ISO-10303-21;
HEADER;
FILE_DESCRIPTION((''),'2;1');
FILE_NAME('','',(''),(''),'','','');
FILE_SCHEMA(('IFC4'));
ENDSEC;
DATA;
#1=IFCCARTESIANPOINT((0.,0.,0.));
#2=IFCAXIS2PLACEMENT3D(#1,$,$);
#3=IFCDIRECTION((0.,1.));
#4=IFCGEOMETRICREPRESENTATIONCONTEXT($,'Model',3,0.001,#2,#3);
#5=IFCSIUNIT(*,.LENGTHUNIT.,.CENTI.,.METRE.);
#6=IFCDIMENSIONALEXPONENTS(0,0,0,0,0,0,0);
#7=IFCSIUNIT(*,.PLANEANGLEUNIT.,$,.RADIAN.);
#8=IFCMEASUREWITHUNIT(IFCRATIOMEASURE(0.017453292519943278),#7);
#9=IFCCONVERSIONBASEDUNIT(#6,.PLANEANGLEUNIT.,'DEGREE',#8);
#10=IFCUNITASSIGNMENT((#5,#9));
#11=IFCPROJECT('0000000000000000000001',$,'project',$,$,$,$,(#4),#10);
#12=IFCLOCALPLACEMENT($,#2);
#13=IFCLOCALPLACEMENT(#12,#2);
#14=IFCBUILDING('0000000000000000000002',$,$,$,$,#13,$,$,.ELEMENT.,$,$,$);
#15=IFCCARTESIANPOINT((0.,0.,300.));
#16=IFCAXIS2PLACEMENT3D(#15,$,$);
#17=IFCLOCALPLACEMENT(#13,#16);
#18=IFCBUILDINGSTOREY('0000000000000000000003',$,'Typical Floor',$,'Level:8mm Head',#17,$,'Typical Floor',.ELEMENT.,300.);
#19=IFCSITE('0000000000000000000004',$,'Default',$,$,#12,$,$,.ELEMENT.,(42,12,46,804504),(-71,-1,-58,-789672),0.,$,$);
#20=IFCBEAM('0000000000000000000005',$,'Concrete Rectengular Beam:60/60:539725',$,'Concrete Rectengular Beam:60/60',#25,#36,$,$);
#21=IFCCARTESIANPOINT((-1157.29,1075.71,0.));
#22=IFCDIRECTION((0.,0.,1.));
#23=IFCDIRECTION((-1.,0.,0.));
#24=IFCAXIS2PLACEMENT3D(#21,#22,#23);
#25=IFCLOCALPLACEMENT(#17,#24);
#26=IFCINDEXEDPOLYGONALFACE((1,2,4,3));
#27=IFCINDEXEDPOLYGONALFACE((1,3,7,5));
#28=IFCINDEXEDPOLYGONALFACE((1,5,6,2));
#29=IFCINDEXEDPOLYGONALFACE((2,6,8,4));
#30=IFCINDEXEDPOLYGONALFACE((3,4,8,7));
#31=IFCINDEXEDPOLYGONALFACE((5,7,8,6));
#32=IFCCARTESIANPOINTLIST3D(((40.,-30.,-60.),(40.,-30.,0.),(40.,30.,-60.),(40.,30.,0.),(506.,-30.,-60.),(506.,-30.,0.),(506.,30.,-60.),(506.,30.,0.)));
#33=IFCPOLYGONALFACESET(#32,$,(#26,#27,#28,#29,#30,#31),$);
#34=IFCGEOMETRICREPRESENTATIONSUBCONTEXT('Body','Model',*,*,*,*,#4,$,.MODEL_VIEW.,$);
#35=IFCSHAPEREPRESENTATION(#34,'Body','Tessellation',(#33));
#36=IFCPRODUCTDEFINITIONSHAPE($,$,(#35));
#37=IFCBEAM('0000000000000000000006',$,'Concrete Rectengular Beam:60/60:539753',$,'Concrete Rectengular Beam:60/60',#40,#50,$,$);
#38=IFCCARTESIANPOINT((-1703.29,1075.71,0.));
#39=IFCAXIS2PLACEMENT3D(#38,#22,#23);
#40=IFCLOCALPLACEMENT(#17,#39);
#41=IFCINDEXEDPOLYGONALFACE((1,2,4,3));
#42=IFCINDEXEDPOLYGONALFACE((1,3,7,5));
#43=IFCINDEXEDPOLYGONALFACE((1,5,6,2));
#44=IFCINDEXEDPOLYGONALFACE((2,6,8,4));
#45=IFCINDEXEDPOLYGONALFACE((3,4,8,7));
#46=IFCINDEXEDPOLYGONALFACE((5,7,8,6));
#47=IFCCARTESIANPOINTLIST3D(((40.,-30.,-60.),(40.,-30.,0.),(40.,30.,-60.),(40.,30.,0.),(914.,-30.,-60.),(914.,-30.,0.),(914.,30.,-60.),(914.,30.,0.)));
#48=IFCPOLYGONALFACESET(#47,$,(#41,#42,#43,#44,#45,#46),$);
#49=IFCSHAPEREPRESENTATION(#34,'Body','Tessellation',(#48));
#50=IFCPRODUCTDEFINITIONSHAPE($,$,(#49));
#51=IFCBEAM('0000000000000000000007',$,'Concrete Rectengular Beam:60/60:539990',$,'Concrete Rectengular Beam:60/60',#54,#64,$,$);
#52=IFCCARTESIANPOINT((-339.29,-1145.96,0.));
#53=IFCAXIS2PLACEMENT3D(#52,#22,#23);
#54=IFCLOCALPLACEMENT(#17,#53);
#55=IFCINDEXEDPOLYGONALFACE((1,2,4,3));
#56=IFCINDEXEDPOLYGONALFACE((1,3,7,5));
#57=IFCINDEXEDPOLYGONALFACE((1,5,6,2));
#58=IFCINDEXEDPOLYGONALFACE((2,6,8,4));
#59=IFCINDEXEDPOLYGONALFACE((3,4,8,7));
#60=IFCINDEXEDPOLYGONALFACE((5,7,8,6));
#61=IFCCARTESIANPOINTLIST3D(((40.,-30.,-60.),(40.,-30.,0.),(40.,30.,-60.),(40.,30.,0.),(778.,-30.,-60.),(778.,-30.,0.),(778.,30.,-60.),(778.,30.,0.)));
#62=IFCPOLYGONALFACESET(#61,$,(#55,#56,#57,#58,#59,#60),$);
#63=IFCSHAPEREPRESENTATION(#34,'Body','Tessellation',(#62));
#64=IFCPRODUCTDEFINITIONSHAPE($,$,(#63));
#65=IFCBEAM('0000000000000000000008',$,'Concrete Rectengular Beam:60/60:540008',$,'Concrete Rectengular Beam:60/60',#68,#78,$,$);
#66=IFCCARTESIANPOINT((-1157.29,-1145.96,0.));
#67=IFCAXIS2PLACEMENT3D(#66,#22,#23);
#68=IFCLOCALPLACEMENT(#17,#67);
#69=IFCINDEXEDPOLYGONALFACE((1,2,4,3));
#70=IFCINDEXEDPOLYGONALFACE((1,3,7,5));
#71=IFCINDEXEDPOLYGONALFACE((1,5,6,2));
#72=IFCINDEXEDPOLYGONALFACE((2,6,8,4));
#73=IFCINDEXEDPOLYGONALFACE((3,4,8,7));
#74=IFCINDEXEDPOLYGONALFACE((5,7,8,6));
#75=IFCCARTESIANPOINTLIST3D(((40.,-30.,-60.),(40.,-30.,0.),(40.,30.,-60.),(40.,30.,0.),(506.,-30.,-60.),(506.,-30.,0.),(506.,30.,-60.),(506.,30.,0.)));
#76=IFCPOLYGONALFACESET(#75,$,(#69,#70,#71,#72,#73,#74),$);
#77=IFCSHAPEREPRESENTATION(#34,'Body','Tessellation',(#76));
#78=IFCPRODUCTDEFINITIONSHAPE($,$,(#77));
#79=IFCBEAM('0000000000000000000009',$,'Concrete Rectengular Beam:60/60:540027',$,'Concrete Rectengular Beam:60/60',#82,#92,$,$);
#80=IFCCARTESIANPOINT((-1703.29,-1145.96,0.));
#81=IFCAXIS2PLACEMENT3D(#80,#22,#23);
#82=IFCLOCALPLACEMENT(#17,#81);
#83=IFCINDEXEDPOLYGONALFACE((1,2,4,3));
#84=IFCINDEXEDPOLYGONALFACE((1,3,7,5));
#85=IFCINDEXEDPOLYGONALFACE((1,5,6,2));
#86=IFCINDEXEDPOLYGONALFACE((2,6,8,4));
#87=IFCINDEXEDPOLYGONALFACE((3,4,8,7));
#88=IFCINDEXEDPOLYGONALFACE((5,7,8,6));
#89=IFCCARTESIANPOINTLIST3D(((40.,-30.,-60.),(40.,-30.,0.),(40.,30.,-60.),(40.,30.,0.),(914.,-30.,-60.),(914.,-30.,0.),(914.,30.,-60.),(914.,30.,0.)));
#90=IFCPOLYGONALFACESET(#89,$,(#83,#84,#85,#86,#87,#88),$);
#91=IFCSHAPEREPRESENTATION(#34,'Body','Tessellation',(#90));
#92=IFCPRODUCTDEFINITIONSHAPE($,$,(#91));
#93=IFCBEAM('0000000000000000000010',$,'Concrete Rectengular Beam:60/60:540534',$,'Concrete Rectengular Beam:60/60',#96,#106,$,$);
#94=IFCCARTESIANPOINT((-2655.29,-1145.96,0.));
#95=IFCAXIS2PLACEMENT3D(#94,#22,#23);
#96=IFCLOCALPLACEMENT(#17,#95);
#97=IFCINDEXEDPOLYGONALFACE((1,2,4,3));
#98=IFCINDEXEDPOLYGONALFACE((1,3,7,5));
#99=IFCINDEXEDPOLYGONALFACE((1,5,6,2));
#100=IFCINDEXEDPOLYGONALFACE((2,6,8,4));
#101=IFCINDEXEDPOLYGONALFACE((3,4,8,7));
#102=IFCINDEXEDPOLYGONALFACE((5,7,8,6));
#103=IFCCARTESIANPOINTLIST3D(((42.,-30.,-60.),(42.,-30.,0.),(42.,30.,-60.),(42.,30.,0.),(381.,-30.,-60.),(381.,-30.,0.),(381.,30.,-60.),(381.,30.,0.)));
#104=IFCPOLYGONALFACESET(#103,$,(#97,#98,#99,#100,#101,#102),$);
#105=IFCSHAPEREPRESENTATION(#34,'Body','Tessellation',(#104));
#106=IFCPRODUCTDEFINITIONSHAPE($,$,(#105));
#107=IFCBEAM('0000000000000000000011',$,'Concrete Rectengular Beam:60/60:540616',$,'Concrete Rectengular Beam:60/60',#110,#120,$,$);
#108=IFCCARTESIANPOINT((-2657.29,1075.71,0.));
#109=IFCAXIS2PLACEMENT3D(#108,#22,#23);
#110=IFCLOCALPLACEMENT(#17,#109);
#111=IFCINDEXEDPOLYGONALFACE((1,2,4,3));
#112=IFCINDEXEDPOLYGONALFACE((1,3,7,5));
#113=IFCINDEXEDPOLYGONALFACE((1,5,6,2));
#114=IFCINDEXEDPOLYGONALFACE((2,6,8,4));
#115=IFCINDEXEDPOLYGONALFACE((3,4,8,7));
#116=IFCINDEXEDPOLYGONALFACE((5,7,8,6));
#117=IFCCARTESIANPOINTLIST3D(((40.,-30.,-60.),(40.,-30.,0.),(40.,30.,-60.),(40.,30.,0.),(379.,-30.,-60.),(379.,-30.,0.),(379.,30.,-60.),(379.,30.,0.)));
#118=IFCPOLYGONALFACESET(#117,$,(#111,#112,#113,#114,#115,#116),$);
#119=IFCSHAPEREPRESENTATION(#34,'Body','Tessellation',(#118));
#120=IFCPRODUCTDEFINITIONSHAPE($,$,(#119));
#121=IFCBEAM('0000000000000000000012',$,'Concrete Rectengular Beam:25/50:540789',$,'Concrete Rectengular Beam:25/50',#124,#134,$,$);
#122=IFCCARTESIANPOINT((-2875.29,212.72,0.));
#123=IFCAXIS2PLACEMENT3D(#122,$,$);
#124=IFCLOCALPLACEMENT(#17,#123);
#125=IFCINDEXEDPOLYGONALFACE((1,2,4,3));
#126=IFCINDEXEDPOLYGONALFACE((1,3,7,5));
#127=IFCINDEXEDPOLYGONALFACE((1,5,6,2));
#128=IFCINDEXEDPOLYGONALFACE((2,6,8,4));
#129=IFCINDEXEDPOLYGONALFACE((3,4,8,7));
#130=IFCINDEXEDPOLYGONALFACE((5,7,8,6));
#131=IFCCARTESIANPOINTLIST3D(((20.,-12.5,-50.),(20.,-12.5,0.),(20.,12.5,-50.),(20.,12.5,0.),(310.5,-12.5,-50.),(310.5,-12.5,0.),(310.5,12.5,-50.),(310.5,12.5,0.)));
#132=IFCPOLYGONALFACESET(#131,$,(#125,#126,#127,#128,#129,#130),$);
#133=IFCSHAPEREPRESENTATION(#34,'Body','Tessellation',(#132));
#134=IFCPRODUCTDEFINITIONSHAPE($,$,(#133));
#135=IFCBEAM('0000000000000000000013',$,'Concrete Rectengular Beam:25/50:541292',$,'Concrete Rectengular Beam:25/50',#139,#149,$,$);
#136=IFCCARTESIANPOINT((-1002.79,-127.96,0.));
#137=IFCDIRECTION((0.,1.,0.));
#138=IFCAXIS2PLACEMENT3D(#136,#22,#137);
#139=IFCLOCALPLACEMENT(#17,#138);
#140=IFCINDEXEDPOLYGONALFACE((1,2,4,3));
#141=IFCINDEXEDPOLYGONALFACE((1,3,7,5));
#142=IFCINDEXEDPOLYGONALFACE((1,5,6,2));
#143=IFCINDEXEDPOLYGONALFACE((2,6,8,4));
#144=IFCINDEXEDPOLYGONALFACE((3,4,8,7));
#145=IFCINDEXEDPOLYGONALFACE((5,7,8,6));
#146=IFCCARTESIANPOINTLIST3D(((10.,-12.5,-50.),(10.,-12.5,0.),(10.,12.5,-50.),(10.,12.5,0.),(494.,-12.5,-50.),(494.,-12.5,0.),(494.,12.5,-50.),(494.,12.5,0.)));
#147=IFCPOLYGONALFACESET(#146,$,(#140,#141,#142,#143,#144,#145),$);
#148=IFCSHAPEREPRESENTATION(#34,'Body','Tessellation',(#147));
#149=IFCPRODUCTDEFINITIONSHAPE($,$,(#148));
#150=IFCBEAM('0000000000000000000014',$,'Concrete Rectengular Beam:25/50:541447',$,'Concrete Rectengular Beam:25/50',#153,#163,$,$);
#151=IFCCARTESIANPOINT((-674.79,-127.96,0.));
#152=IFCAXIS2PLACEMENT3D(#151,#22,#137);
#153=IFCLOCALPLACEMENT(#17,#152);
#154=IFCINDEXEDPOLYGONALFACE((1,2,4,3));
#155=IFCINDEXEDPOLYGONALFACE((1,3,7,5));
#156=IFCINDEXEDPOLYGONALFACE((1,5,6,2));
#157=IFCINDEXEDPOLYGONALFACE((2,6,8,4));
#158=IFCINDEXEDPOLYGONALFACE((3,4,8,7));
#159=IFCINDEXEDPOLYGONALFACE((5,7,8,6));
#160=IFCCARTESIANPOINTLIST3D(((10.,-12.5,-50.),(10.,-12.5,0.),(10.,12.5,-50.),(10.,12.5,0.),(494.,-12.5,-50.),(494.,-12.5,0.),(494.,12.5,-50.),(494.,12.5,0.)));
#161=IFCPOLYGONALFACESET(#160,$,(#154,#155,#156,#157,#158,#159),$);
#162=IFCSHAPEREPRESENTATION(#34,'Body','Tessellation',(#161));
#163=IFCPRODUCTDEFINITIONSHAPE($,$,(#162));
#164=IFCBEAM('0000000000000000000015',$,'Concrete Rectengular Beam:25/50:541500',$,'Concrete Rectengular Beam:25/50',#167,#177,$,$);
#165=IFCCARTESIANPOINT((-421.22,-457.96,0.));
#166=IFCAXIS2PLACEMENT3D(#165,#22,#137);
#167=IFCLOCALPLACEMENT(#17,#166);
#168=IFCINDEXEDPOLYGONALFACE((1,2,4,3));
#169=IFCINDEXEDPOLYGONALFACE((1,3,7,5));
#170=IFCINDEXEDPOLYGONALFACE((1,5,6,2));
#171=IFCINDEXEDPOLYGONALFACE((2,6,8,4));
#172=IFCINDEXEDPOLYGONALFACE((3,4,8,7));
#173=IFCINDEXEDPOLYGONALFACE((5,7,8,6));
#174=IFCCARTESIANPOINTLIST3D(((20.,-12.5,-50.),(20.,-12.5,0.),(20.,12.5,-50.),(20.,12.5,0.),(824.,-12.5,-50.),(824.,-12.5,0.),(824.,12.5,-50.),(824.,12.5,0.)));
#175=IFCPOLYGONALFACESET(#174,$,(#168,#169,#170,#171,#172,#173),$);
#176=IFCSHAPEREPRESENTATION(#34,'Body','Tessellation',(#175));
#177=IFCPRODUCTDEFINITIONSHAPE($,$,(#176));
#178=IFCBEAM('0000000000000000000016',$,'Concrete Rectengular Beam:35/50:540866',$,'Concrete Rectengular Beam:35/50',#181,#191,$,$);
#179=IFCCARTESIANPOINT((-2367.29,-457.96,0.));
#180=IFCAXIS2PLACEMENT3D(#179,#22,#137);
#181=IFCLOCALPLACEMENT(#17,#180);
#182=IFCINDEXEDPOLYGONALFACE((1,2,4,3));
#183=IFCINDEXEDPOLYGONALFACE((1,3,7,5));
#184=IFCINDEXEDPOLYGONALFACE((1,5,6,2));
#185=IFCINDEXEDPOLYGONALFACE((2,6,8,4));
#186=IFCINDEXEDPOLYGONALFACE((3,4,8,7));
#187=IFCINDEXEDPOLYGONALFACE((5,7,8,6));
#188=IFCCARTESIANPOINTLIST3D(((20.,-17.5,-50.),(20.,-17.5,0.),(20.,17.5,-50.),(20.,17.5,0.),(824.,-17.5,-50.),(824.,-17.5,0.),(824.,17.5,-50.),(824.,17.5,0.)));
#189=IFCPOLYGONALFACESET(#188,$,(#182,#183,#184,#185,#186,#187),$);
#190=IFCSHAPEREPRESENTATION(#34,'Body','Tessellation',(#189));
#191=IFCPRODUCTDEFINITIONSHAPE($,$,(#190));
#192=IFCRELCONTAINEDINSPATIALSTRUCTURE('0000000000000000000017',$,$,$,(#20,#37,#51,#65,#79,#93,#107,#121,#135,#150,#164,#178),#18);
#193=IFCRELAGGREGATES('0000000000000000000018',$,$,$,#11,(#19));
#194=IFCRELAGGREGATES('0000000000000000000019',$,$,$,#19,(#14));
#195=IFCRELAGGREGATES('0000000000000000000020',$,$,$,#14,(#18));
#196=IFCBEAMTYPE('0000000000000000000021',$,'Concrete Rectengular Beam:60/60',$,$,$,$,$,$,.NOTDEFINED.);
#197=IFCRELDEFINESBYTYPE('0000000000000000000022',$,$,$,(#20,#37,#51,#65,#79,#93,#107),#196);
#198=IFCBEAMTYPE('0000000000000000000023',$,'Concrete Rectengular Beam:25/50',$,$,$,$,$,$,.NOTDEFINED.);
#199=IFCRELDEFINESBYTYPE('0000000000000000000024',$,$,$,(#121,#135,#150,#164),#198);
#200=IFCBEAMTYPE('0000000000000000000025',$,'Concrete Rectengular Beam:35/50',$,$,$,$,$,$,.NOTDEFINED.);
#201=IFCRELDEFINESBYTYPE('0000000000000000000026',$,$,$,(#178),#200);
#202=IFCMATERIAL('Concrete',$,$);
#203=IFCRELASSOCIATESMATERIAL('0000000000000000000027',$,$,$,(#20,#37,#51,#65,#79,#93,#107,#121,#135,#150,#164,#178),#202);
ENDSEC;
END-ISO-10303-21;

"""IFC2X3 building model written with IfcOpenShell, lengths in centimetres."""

from ifc_helpers import new_model, entity, si_unit, converted_unit, direction, frame, frame_2d, origin, origin_2d_with_axis, place, context, subcontext, project, spatial, rectangle, extrude, material, type_object, element, save


model = new_model("IFC2X3")

# Units and contexts
model_context = context("Model", 3, precision=0.001, world=origin(), true_north=direction((0.0, 1.0)))
body_context = subcontext(model_context, "Body", "Model", "MODEL_VIEW")
ifc_project = project(units=[si_unit("LENGTHUNIT", "METRE", prefix="CENTI"), converted_unit("PLANEANGLEUNIT", "DEGREE", entity("IfcRatioMeasure", 0.017453292519943278), si_unit("PLANEANGLEUNIT", "RADIAN"), dimensions=[0, 0, 0, 0, 0, 0, 0])], contexts=[model_context])

# Site, building, storey
site_placement = place(None, origin())
site = spatial("IfcSite", under=ifc_project, at=site_placement, Name="Default", CompositionType="ELEMENT", RefLatitude=(42, 12, 46, 804504), RefLongitude=(-71, -1, -58, -789672), RefElevation=0.0)
building_placement = place(site_placement, origin())
building = spatial("IfcBuilding", under=site, at=building_placement, CompositionType="ELEMENT")
storey_placement = place(building_placement, frame((0.0, 0.0, 300.0)))
storey = spatial("IfcBuildingStorey", under=building, at=storey_placement, Name="Typical Floor", ObjectType="Level:8mm Head", LongName="Typical Floor", CompositionType="ELEMENT", Elevation=300.0)

# Beams
ifc_material = material(Name="Concrete")
beam_type_1 = type_object("IfcBeamType", Name="Concrete Rectengular Beam:60/60", PredefinedType="NOTDEFINED")
beam_1_placement = place(storey_placement, frame((-1157.29, 1075.71, 0.0), z_axis=(0.0, 0.0, 1.0), x_axis=(-1.0, 0.0, 0.0)))
element("IfcBeam", 1, at=beam_1_placement, inside=storey, type_object=beam_type_1, material=ifc_material, Name="Concrete Rectengular Beam:60/60:539725", ObjectType="Concrete Rectengular Beam:60/60", context=body_context, shape_type="SweptSolid", body=[
    extrude(rectangle(XDim=60.0, YDim=60.0, at=frame_2d((0.0, 0.0), x_axis=(1.0, 0.0))), frame((40.0, 0.0, -30.0), z_axis=(1.0, 0.0, 0.0), x_axis=(0.0, 0.0, -1.0)), (0.0, 0.0, 1.0), 466.0),
])
beam_2_placement = place(storey_placement, frame((-1703.29, 1075.71, 0.0), z_axis=(0.0, 0.0, 1.0), x_axis=(-1.0, 0.0, 0.0)))
element("IfcBeam", 2, at=beam_2_placement, inside=storey, type_object=beam_type_1, material=ifc_material, Name="Concrete Rectengular Beam:60/60:539753", ObjectType="Concrete Rectengular Beam:60/60", context=body_context, shape_type="SweptSolid", body=[
    extrude(rectangle(XDim=60.0, YDim=60.0, at=frame_2d((0.0, 0.0), x_axis=(1.0, 0.0))), frame((40.0, 0.0, -30.0), z_axis=(1.0, 0.0, 0.0), x_axis=(0.0, 0.0, -1.0)), (0.0, 0.0, 1.0), 874.0),
])
beam_3_placement = place(storey_placement, frame((-339.29, -1145.96, 0.0), z_axis=(0.0, 0.0, 1.0), x_axis=(-1.0, 0.0, 0.0)))
element("IfcBeam", 3, at=beam_3_placement, inside=storey, type_object=beam_type_1, material=ifc_material, Name="Concrete Rectengular Beam:60/60:539990", ObjectType="Concrete Rectengular Beam:60/60", context=body_context, shape_type="SweptSolid", body=[
    extrude(rectangle(XDim=60.0, YDim=60.0, at=frame_2d((0.0, 0.0), x_axis=(1.0, 0.0))), frame((40.0, 0.0, -30.0), z_axis=(1.0, 0.0, 0.0), x_axis=(0.0, 0.0, -1.0)), (0.0, 0.0, 1.0), 738.0),
])
beam_4_placement = place(storey_placement, frame((-1157.29, -1145.96, 0.0), z_axis=(0.0, 0.0, 1.0), x_axis=(-1.0, 0.0, 0.0)))
element("IfcBeam", 4, at=beam_4_placement, inside=storey, type_object=beam_type_1, material=ifc_material, Name="Concrete Rectengular Beam:60/60:540008", ObjectType="Concrete Rectengular Beam:60/60", context=body_context, shape_type="SweptSolid", body=[
    extrude(rectangle(XDim=60.0, YDim=60.0, at=frame_2d((0.0, 0.0), x_axis=(1.0, 0.0))), frame((40.0, 0.0, -30.0), z_axis=(1.0, 0.0, 0.0), x_axis=(0.0, 0.0, -1.0)), (0.0, 0.0, 1.0), 466.0),
])
beam_5_placement = place(storey_placement, frame((-1703.29, -1145.96, 0.0), z_axis=(0.0, 0.0, 1.0), x_axis=(-1.0, 0.0, 0.0)))
element("IfcBeam", 5, at=beam_5_placement, inside=storey, type_object=beam_type_1, material=ifc_material, Name="Concrete Rectengular Beam:60/60:540027", ObjectType="Concrete Rectengular Beam:60/60", context=body_context, shape_type="SweptSolid", body=[
    extrude(rectangle(XDim=60.0, YDim=60.0, at=frame_2d((0.0, 0.0), x_axis=(1.0, 0.0))), frame((40.0, 0.0, -30.0), z_axis=(1.0, 0.0, 0.0), x_axis=(0.0, 0.0, -1.0)), (0.0, 0.0, 1.0), 874.0),
])
beam_6_placement = place(storey_placement, frame((-2655.29, -1145.96, 0.0), z_axis=(0.0, 0.0, 1.0), x_axis=(-1.0, 0.0, 0.0)))
element("IfcBeam", 6, at=beam_6_placement, inside=storey, type_object=beam_type_1, material=ifc_material, Name="Concrete Rectengular Beam:60/60:540534", ObjectType="Concrete Rectengular Beam:60/60", context=body_context, shape_type="SweptSolid", body=[
    extrude(rectangle(XDim=60.0, YDim=60.0, at=frame_2d((0.0, 0.0), x_axis=(1.0, 0.0))), frame((42.0, 0.0, -30.0), z_axis=(1.0, 0.0, 0.0), x_axis=(0.0, 0.0, -1.0)), (0.0, 0.0, 1.0), 339.0),
])
beam_7_placement = place(storey_placement, frame((-2657.29, 1075.71, 0.0), z_axis=(0.0, 0.0, 1.0), x_axis=(-1.0, 0.0, 0.0)))
element("IfcBeam", 7, at=beam_7_placement, inside=storey, type_object=beam_type_1, material=ifc_material, Name="Concrete Rectengular Beam:60/60:540616", ObjectType="Concrete Rectengular Beam:60/60", context=body_context, shape_type="SweptSolid", body=[
    extrude(rectangle(XDim=60.0, YDim=60.0, at=frame_2d((0.0, 0.0), x_axis=(1.0, 0.0))), frame((40.0, 0.0, -30.0), z_axis=(1.0, 0.0, 0.0), x_axis=(0.0, 0.0, -1.0)), (0.0, 0.0, 1.0), 339.0),
])
beam_type_2 = type_object("IfcBeamType", Name="Concrete Rectengular Beam:25/50", PredefinedType="NOTDEFINED")
beam_8_placement = place(storey_placement, frame((-2875.29, 212.72, 0.0)))
element("IfcBeam", 8, at=beam_8_placement, inside=storey, type_object=beam_type_2, material=ifc_material, Name="Concrete Rectengular Beam:25/50:540789", ObjectType="Concrete Rectengular Beam:25/50", context=body_context, shape_type="SweptSolid", body=[
    extrude(rectangle(XDim=50.0, YDim=25.0, at=frame_2d((0.0, 0.0), x_axis=(1.0, 0.0))), frame((20.0, 0.0, -25.0), z_axis=(1.0, 0.0, 0.0), x_axis=(0.0, 0.0, -1.0)), (0.0, 0.0, 1.0), 290.5),
])
beam_9_placement = place(storey_placement, frame((-1002.79, -127.96, 0.0), z_axis=(0.0, 0.0, 1.0), x_axis=(0.0, 1.0, 0.0)))
element("IfcBeam", 9, at=beam_9_placement, inside=storey, type_object=beam_type_2, material=ifc_material, Name="Concrete Rectengular Beam:25/50:541292", ObjectType="Concrete Rectengular Beam:25/50", context=body_context, shape_type="SweptSolid", body=[
    extrude(rectangle(XDim=50.0, YDim=25.0, at=origin_2d_with_axis()), frame((10.0, 0.0, -25.0), z_axis=(1.0, 0.0, 0.0), x_axis=(0.0, 0.0, -1.0)), (0.0, 0.0, 1.0), 484.0),
])
beam_10_placement = place(storey_placement, frame((-674.79, -127.96, 0.0), z_axis=(0.0, 0.0, 1.0), x_axis=(0.0, 1.0, 0.0)))
element("IfcBeam", 10, at=beam_10_placement, inside=storey, type_object=beam_type_2, material=ifc_material, Name="Concrete Rectengular Beam:25/50:541447", ObjectType="Concrete Rectengular Beam:25/50", context=body_context, shape_type="SweptSolid", body=[
    extrude(rectangle(XDim=50.0, YDim=25.0, at=origin_2d_with_axis()), frame((10.0, 0.0, -25.0), z_axis=(1.0, 0.0, 0.0), x_axis=(0.0, 0.0, -1.0)), (0.0, 0.0, 1.0), 484.0),
])
beam_11_placement = place(storey_placement, frame((-421.22, -457.96, 0.0), z_axis=(0.0, 0.0, 1.0), x_axis=(0.0, 1.0, 0.0)))
element("IfcBeam", 11, at=beam_11_placement, inside=storey, type_object=beam_type_2, material=ifc_material, Name="Concrete Rectengular Beam:25/50:541500", ObjectType="Concrete Rectengular Beam:25/50", context=body_context, shape_type="SweptSolid", body=[
    extrude(rectangle(XDim=50.0, YDim=25.0, at=frame_2d((0.0, 0.0), x_axis=(1.0, 0.0))), frame((20.0, 0.0, -25.0), z_axis=(1.0, 0.0, 0.0), x_axis=(0.0, 0.0, -1.0)), (0.0, 0.0, 1.0), 804.0),
])
beam_type_3 = type_object("IfcBeamType", Name="Concrete Rectengular Beam:35/50", PredefinedType="NOTDEFINED")
beam_12_placement = place(storey_placement, frame((-2367.29, -457.96, 0.0), z_axis=(0.0, 0.0, 1.0), x_axis=(0.0, 1.0, 0.0)))
element("IfcBeam", 12, at=beam_12_placement, inside=storey, type_object=beam_type_3, material=ifc_material, Name="Concrete Rectengular Beam:35/50:540866", ObjectType="Concrete Rectengular Beam:35/50", context=body_context, shape_type="SweptSolid", body=[
    extrude(rectangle(XDim=50.0, YDim=35.0, at=frame_2d((0.0, 0.0), x_axis=(1.0, 0.0))), frame((20.0, 0.0, -25.0), z_axis=(1.0, 0.0, 0.0), x_axis=(0.0, 0.0, -1.0)), (0.0, 0.0, 1.0), 804.0),
])

save(model, "model.ifc")
